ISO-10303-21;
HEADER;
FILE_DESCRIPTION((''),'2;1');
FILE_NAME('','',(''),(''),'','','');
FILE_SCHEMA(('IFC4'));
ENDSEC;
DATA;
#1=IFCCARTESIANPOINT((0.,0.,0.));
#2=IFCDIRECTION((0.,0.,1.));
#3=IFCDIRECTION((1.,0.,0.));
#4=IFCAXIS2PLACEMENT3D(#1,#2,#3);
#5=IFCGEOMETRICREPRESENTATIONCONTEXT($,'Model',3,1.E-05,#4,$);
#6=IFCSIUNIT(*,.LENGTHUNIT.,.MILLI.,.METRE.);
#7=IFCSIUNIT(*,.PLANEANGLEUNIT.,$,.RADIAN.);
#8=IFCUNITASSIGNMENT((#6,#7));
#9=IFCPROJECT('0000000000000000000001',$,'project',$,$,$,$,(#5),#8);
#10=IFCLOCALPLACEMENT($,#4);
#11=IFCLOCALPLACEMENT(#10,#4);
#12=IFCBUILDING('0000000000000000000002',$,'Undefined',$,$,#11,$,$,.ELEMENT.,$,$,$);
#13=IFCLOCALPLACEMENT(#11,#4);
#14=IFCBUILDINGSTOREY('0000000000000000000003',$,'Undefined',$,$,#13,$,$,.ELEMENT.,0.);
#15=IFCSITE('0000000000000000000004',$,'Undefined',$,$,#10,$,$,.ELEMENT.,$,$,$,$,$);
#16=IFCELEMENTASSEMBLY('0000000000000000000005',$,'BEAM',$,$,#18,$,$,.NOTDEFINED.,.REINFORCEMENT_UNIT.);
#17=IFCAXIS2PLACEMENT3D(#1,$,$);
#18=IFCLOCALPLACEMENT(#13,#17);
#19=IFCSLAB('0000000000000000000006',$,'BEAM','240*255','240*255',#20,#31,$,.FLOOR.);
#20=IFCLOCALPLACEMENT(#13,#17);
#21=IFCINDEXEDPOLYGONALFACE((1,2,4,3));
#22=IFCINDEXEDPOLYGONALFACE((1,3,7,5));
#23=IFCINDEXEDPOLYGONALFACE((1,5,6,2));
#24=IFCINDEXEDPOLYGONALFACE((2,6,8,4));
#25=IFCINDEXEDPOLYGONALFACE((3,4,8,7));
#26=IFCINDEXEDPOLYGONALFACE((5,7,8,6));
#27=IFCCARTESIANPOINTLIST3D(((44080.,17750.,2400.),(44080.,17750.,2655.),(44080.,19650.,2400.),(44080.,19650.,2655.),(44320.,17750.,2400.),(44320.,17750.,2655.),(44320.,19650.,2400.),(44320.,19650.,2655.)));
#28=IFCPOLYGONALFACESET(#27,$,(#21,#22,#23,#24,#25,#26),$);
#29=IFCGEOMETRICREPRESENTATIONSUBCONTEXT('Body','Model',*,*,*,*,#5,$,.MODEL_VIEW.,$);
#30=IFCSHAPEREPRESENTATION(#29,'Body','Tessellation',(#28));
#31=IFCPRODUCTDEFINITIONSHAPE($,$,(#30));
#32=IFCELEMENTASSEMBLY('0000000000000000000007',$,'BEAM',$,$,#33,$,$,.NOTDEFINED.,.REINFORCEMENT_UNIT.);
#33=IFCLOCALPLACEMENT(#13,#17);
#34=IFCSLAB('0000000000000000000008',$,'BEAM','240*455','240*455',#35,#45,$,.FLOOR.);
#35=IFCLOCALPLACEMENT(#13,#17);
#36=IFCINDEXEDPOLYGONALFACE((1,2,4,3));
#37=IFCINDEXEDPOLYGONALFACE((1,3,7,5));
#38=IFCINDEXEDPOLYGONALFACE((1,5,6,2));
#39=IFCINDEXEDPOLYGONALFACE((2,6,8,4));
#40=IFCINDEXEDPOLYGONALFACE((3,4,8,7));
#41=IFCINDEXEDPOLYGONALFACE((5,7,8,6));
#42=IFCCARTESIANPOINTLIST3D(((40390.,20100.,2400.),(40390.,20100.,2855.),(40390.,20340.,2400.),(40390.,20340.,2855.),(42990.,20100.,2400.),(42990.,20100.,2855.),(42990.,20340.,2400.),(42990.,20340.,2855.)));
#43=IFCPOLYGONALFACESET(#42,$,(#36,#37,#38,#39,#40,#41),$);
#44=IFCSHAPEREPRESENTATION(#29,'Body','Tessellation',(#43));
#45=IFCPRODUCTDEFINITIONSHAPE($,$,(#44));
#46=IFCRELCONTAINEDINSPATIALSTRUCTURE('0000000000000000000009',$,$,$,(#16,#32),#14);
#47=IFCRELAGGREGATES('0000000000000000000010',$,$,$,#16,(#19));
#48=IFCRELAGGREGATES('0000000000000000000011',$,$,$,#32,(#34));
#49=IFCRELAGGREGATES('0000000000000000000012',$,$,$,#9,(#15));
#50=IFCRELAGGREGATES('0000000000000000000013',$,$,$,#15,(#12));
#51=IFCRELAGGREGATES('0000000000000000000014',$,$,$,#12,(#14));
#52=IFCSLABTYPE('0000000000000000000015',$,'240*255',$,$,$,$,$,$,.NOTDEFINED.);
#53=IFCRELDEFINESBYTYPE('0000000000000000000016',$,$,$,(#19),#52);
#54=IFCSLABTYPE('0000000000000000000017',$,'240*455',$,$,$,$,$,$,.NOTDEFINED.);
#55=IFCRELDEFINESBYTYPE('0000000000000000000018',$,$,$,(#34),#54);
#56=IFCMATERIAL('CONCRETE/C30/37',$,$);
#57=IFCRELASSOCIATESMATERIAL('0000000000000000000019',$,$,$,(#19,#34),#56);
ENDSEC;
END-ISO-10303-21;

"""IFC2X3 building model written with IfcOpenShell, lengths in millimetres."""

from ifc_helpers import new_model, si_unit, frame, origin_with_axes, place, context, subcontext, project, spatial, polyline, outline, extrude, material, type_object, element, aggregate, save


model = new_model("IFC2X3")

# Units and contexts
model_context = context("Model", 3, precision=1e-05, world=origin_with_axes())
body_context = subcontext(model_context, "Body", "Model", "MODEL_VIEW")
ifc_project = project(units=[si_unit("LENGTHUNIT", "METRE", prefix="MILLI"), si_unit("PLANEANGLEUNIT", "RADIAN")], contexts=[model_context])

# Site, building, storey
site_placement = place(None, origin_with_axes())
site = spatial("IfcSite", under=ifc_project, at=site_placement, Name="Undefined", CompositionType="ELEMENT")
building_placement = place(site_placement, origin_with_axes())
building = spatial("IfcBuilding", under=site, at=building_placement, Name="Undefined", CompositionType="ELEMENT")
storey_placement = place(building_placement, origin_with_axes())
storey = spatial("IfcBuildingStorey", under=building, at=storey_placement, Name="Undefined", CompositionType="ELEMENT", Elevation=0.0)

# Element assemblies, slabs
assembly_1_placement = place(storey_placement, origin_with_axes())
assembly_1 = element("IfcElementAssembly", 1, at=assembly_1_placement, inside=storey, Name="BEAM", AssemblyPlace="NOTDEFINED", PredefinedType="REINFORCEMENT_UNIT")
ifc_material_1 = material(Name="CONCRETE/C30/37")
slab_type_1 = type_object("IfcSlabType", Name="240*255", PredefinedType="NOTDEFINED")
slab_1_placement = place(assembly_1_placement, frame((44200.0, 17750.0, 2400.0), z_axis=(-1.0, 0.0, 0.0), x_axis=(0.0, 0.000002, 1.0)))
slab_1 = element("IfcSlab", 2, at=slab_1_placement, type_object=slab_type_1, material=ifc_material_1, Name="BEAM", Description="240*255", ObjectType="240*255", PredefinedType="FLOOR", context=body_context, shape_type="SweptSolid", body=[
    extrude(outline(polyline([(0.0, 0.0), (255.0, 0.0), (255.0, 1900.0), (0.0, 1900.0), (0.0, 0.0)])), frame((0.0, 0.0, -120.0), z_axis=(0.0, 0.0, 1.0), x_axis=(1.0, 0.0, 0.0)), (0.0, 0.0, 1.0), 240.0),
])
assembly_2_placement = place(storey_placement, origin_with_axes())
assembly_2 = element("IfcElementAssembly", 3, at=assembly_2_placement, inside=storey, Name="BEAM", AssemblyPlace="NOTDEFINED", PredefinedType="REINFORCEMENT_UNIT")
slab_type_2 = type_object("IfcSlabType", Name="240*455", PredefinedType="NOTDEFINED")
slab_2_placement = place(assembly_2_placement, frame((42990.0, 20220.0, 2400.0), z_axis=(0.0, -1.0, 0.0), x_axis=(0.0, 0.0, 1.0)))
slab_2 = element("IfcSlab", 4, at=slab_2_placement, type_object=slab_type_2, material=ifc_material_1, Name="BEAM", Description="240*455", ObjectType="240*455", PredefinedType="FLOOR", context=body_context, shape_type="SweptSolid", body=[
    extrude(outline(polyline([(0.0, 0.0), (455.0, 0.0), (455.0, 2600.0), (0.0, 2600.0), (0.0, 0.0)])), frame((0.0, 0.0, -120.0), z_axis=(0.0, 0.0, 1.0), x_axis=(1.0, 0.0, 0.0)), (0.0, 0.0, 1.0), 240.0),
])

aggregate(assembly_1, [slab_1])

aggregate(assembly_2, [slab_2])

save(model, "model.ifc")
